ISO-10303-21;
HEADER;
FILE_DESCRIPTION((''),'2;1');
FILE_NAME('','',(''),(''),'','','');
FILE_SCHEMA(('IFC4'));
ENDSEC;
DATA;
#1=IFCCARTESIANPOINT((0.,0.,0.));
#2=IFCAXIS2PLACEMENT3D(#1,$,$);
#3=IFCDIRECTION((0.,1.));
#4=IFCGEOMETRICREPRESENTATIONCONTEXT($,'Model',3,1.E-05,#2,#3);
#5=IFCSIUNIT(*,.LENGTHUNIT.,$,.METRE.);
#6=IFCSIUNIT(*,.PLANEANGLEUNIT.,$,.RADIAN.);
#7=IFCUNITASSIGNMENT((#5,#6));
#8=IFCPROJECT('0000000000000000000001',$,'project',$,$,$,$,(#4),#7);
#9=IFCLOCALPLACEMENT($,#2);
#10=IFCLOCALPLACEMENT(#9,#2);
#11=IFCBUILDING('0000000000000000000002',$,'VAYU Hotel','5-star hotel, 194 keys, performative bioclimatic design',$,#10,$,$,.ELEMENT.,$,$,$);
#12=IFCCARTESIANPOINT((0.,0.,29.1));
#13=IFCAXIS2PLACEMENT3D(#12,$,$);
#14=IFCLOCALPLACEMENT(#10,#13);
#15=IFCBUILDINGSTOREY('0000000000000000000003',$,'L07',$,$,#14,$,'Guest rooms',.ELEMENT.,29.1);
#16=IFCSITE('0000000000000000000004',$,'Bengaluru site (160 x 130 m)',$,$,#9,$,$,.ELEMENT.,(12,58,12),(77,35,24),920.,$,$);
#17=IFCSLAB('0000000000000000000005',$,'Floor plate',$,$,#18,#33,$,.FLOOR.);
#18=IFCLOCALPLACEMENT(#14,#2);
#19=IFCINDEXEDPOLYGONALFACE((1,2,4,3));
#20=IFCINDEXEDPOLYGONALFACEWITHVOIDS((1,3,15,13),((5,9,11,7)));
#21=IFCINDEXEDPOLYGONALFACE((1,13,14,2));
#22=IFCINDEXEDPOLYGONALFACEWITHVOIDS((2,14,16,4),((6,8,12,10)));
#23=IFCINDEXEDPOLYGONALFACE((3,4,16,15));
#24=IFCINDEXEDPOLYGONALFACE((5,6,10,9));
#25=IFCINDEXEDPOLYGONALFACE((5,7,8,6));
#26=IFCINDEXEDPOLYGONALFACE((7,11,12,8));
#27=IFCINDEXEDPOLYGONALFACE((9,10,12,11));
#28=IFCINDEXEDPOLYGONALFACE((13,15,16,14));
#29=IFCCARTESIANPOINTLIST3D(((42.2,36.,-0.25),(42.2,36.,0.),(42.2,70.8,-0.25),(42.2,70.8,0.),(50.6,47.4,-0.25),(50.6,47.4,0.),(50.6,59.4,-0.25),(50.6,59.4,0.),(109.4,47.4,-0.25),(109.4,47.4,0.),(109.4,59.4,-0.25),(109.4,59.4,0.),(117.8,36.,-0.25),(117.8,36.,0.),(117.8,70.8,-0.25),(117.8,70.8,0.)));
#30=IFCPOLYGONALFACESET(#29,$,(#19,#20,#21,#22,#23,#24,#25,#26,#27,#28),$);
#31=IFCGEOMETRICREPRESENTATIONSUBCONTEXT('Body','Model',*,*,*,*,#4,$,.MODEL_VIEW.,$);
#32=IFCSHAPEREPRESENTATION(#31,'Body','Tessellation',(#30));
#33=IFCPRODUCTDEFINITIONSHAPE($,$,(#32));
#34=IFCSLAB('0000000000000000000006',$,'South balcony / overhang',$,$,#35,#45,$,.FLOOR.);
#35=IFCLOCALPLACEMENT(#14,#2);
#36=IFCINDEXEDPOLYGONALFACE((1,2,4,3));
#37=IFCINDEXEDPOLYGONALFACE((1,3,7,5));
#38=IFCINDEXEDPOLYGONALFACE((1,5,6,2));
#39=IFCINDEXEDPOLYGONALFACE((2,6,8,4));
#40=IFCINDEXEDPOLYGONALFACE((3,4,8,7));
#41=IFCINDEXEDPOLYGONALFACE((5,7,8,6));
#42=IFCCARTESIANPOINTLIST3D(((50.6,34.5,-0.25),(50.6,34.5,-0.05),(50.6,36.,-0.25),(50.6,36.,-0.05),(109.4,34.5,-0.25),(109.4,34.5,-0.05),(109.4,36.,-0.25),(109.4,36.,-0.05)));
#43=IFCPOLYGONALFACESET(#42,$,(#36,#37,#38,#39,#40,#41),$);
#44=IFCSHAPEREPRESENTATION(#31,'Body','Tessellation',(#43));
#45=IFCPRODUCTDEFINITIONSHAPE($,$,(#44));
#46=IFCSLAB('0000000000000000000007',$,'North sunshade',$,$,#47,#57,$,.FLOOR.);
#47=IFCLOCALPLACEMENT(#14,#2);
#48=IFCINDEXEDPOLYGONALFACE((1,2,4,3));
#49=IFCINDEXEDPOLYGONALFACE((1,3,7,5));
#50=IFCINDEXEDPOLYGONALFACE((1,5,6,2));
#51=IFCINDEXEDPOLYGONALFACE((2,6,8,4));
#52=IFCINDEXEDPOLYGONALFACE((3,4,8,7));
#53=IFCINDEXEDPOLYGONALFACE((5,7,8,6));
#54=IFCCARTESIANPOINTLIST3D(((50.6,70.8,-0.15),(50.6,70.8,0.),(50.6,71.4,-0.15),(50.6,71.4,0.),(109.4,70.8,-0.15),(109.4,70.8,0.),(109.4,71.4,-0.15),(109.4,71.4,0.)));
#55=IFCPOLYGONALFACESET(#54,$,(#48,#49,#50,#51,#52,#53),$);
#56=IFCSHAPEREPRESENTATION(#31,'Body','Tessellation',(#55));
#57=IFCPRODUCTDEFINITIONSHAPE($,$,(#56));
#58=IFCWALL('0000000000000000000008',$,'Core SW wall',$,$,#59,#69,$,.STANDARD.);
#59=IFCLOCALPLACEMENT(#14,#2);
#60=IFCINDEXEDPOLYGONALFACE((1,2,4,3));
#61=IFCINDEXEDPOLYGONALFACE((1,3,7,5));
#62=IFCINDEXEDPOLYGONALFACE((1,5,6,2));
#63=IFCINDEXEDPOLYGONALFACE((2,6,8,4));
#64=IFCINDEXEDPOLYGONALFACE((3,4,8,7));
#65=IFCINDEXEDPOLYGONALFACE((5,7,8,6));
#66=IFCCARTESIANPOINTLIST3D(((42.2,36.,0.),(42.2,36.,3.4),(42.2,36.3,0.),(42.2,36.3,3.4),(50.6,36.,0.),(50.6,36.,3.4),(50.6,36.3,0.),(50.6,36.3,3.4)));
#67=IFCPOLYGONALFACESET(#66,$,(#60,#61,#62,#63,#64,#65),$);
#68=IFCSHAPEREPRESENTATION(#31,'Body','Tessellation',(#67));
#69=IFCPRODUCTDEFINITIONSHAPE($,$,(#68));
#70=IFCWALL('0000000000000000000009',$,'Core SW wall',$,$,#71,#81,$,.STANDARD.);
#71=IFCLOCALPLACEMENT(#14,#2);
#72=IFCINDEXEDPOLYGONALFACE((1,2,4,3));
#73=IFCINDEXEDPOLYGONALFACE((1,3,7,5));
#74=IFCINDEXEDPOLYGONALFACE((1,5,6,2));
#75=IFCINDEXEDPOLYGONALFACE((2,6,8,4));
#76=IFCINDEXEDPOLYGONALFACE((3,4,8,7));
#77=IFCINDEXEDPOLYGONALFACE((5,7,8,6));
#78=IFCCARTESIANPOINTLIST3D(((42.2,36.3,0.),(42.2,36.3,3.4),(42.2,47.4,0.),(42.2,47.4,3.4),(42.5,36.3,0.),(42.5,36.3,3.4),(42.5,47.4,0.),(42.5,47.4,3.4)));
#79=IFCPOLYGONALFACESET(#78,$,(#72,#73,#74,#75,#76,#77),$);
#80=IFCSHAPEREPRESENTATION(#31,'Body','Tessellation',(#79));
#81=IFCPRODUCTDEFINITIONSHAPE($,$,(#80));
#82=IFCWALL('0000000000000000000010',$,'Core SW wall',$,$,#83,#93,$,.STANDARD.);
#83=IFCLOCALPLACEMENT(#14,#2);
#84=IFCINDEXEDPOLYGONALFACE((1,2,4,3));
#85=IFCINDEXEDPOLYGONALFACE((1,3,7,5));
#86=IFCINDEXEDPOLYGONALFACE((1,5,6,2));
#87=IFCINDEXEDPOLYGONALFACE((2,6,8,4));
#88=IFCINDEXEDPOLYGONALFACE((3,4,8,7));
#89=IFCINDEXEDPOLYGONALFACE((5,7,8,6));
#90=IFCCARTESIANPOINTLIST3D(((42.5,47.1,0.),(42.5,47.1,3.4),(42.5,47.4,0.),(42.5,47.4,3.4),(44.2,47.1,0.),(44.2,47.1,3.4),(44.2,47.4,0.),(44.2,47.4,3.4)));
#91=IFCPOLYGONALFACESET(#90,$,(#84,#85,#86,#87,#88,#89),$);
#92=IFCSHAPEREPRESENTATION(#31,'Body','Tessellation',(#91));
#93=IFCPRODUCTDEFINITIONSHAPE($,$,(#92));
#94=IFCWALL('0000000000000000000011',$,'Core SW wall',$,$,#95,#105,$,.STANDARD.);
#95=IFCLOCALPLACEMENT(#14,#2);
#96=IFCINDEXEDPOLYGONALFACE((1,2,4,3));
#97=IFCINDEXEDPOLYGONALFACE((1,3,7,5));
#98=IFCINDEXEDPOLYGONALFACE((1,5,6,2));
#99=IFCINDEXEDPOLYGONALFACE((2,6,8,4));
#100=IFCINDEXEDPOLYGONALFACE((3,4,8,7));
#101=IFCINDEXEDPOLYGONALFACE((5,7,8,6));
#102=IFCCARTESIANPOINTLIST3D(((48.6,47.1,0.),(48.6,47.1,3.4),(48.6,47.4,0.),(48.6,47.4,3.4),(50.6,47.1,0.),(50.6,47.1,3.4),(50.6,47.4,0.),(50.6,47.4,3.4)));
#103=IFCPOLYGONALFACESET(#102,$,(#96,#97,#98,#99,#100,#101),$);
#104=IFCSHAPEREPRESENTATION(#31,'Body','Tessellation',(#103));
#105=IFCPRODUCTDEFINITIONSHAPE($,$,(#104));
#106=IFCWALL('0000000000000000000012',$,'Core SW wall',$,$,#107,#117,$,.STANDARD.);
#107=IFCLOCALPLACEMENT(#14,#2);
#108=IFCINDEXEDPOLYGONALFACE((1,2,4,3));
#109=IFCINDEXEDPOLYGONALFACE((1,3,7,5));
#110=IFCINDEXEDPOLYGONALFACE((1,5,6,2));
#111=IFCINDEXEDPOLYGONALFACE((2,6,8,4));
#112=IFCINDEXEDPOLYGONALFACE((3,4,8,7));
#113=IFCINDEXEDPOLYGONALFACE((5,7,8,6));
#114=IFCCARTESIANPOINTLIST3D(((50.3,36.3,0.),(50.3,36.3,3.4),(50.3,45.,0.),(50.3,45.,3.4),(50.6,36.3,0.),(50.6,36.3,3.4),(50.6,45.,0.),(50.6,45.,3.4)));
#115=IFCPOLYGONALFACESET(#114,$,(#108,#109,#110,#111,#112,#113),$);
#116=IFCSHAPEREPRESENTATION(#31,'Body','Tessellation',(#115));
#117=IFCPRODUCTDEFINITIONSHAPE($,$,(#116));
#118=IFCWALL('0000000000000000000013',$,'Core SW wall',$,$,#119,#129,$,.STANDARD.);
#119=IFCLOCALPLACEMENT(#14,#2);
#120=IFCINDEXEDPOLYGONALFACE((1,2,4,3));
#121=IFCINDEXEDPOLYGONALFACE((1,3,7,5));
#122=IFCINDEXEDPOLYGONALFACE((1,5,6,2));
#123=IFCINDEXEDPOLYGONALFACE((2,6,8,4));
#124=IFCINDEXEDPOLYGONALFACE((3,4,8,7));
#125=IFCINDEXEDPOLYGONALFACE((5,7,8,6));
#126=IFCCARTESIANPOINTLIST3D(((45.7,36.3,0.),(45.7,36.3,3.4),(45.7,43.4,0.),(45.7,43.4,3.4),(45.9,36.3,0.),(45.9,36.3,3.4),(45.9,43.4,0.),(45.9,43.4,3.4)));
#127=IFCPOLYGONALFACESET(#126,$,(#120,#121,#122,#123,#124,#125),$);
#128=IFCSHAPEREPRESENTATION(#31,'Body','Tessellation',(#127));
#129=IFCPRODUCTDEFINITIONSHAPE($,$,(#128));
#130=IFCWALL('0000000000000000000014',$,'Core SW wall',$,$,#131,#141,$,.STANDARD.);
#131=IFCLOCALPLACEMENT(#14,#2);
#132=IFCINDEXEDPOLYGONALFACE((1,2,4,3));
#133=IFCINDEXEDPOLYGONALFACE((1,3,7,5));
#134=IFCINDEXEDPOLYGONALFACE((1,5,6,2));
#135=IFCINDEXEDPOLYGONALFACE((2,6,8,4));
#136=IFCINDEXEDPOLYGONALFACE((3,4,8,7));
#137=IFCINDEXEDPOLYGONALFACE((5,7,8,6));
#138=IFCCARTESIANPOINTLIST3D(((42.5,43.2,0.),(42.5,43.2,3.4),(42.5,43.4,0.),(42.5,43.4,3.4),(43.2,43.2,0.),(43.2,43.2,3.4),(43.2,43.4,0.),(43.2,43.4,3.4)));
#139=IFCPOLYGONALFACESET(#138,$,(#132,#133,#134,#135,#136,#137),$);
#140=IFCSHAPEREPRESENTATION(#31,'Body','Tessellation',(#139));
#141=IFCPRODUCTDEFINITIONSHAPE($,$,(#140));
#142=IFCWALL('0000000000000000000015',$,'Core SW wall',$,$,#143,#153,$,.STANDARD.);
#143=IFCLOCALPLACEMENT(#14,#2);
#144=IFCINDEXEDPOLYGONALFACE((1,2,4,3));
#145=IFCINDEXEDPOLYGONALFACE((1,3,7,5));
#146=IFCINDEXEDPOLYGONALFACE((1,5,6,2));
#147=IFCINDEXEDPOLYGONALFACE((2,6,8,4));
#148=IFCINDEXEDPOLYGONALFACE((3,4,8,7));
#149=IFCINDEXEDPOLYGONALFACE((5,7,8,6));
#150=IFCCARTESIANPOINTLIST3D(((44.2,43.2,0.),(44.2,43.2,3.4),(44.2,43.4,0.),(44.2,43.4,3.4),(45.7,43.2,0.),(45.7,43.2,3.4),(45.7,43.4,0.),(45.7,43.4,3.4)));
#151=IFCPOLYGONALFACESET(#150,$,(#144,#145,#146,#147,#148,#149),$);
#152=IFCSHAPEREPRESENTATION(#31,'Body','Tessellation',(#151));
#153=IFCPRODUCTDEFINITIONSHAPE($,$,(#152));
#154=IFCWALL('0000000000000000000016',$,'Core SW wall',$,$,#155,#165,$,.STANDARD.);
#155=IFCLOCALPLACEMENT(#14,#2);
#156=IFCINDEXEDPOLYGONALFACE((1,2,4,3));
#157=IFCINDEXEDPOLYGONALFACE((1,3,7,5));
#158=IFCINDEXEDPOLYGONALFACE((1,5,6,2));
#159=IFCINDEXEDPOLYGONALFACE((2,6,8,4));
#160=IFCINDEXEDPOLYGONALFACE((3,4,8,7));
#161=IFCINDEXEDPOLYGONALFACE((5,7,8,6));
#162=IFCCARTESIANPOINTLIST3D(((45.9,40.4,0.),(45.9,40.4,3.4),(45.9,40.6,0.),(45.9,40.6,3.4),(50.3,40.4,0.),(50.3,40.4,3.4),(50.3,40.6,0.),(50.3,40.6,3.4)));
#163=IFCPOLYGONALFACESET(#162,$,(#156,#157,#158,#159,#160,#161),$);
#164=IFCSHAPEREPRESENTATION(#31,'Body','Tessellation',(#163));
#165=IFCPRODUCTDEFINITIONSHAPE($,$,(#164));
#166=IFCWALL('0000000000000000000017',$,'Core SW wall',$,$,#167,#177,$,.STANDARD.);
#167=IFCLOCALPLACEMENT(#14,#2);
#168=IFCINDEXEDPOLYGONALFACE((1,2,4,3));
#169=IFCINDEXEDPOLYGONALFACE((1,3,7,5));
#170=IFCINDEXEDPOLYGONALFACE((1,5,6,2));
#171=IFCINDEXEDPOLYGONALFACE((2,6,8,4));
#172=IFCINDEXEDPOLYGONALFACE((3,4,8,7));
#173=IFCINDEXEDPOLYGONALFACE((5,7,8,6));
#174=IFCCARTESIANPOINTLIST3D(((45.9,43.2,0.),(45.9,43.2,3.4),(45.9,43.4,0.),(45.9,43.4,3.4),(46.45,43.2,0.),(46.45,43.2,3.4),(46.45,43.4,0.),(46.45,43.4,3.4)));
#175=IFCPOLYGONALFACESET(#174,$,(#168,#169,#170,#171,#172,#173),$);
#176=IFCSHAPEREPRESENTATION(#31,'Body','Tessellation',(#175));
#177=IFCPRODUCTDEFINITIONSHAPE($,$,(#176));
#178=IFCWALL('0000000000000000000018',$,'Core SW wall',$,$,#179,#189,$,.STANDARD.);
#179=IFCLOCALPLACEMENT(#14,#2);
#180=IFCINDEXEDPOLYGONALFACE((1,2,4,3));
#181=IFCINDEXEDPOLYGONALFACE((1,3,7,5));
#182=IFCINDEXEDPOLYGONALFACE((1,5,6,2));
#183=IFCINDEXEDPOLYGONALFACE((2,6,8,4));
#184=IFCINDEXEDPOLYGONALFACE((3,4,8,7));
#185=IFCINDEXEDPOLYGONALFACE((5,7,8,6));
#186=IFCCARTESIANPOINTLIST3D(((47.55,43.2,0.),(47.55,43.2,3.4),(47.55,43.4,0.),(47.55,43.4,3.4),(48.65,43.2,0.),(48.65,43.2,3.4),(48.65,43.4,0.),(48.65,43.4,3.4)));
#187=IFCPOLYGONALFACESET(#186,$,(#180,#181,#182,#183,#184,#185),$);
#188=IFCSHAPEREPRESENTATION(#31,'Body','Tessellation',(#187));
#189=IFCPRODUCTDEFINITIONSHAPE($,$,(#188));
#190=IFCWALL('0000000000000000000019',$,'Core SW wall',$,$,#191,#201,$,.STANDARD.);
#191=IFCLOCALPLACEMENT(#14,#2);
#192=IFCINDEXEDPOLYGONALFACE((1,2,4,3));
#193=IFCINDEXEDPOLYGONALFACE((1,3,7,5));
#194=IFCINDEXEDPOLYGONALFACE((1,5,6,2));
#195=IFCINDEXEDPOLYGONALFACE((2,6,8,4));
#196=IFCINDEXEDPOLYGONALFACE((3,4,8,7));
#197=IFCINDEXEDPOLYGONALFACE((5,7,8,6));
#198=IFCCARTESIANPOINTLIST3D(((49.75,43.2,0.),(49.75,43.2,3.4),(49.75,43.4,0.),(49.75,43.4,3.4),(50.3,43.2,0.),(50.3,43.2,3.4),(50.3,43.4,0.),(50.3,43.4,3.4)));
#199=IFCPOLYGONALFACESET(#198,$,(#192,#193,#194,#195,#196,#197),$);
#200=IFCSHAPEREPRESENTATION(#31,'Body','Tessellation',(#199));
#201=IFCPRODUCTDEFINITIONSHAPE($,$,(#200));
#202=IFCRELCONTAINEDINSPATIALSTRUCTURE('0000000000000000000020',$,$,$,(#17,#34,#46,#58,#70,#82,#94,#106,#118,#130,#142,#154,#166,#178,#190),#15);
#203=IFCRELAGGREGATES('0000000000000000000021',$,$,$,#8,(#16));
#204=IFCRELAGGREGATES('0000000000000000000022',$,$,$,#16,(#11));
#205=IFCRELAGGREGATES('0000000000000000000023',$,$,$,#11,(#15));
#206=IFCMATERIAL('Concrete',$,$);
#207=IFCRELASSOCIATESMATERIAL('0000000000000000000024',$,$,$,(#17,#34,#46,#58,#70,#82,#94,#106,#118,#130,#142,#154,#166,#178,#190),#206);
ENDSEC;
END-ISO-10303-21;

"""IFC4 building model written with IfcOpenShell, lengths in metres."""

from ifc_helpers import new_model, si_unit, direction, frame, origin, place, context, subcontext, project, spatial, polyline, outline, extrude, material, element, save


model = new_model("IFC4")

# Units and contexts
model_context = context("Model", 3, precision=1e-05, world=origin(), true_north=direction((0.0, 1.0)))
body_context = subcontext(model_context, "Body", "Model", "MODEL_VIEW")
ifc_project = project(units=[si_unit("LENGTHUNIT", "METRE"), si_unit("PLANEANGLEUNIT", "RADIAN")], contexts=[model_context])

# Site, building, storey
site_placement = place(None, origin())
site = spatial("IfcSite", under=ifc_project, at=site_placement, Name="Bengaluru site (160 x 130 m)", CompositionType="ELEMENT", RefLatitude=(12, 58, 12), RefLongitude=(77, 35, 24), RefElevation=920.0)
building_placement = place(site_placement, origin())
building = spatial("IfcBuilding", under=site, at=building_placement, Name="VAYU Hotel", Description="5-star hotel, 194 keys, performative bioclimatic design", CompositionType="ELEMENT")
storey_placement = place(building_placement, frame((0.0, 0.0, 29.1)))
storey = spatial("IfcBuildingStorey", under=building, at=storey_placement, Name="L07", LongName="Guest rooms", CompositionType="ELEMENT", Elevation=29.1)

# Slabs
ifc_material_1 = material(Name="Concrete")
slab_1_placement = place(storey_placement, origin())
element("IfcSlab", 1, at=slab_1_placement, inside=storey, material=ifc_material_1, Name="Floor plate", PredefinedType="FLOOR", context=body_context, shape_type="SweptSolid", body=[
    extrude(outline(polyline([(42.2, 36.0), (117.8, 36.0), (117.8, 70.8), (42.2, 70.8), (42.2, 36.0)]), holes=[polyline([(50.6, 47.4), (109.4, 47.4), (109.4, 59.4), (50.6, 59.4), (50.6, 47.4)])]), frame((0.0, 0.0, -0.25)), (0.0, 0.0, 1.0), 0.25),
])
slab_2_placement = place(storey_placement, origin())
element("IfcSlab", 2, at=slab_2_placement, inside=storey, material=ifc_material_1, Name="South balcony / overhang", PredefinedType="FLOOR", context=body_context, shape_type="SweptSolid", body=[
    extrude(outline(polyline([(50.6, 34.5), (109.4, 34.5), (109.4, 36.0), (50.6, 36.0), (50.6, 34.5)])), frame((0.0, 0.0, -0.25)), (0.0, 0.0, 1.0), 0.2),
])
slab_3_placement = place(storey_placement, origin())
element("IfcSlab", 3, at=slab_3_placement, inside=storey, material=ifc_material_1, Name="North sunshade", PredefinedType="FLOOR", context=body_context, shape_type="SweptSolid", body=[
    extrude(outline(polyline([(50.6, 70.8), (109.4, 70.8), (109.4, 71.4), (50.6, 71.4), (50.6, 70.8)])), frame((0.0, 0.0, -0.15)), (0.0, 0.0, 1.0), 0.15),
])

# Walls
wall_1_placement = place(storey_placement, origin())
element("IfcWall", 4, at=wall_1_placement, inside=storey, material=ifc_material_1, Name="Core SW wall", PredefinedType="STANDARD", context=body_context, shape_type="SweptSolid", body=[
    extrude(outline(polyline([(42.2, 36.3), (50.6, 36.3), (50.6, 36.0), (42.2, 36.0), (42.2, 36.3)])), origin(), (0.0, 0.0, 1.0), 3.4),
])
wall_2_placement = place(storey_placement, origin())
element("IfcWall", 5, at=wall_2_placement, inside=storey, material=ifc_material_1, Name="Core SW wall", PredefinedType="STANDARD", context=body_context, shape_type="SweptSolid", body=[
    extrude(outline(polyline([(42.2, 36.3), (42.2, 47.4), (42.5, 47.4), (42.5, 36.3), (42.2, 36.3)])), origin(), (0.0, 0.0, 1.0), 3.4),
])
wall_3_placement = place(storey_placement, origin())
element("IfcWall", 6, at=wall_3_placement, inside=storey, material=ifc_material_1, Name="Core SW wall", PredefinedType="STANDARD", context=body_context, shape_type="SweptSolid", body=[
    extrude(outline(polyline([(42.5, 47.4), (44.2, 47.4), (44.2, 47.1), (42.5, 47.1), (42.5, 47.4)])), origin(), (0.0, 0.0, 1.0), 3.4),
])
wall_4_placement = place(storey_placement, origin())
element("IfcWall", 7, at=wall_4_placement, inside=storey, material=ifc_material_1, Name="Core SW wall", PredefinedType="STANDARD", context=body_context, shape_type="SweptSolid", body=[
    extrude(outline(polyline([(48.6, 47.4), (50.6, 47.4), (50.6, 47.1), (48.6, 47.1), (48.6, 47.4)])), origin(), (0.0, 0.0, 1.0), 3.4),
])
wall_5_placement = place(storey_placement, origin())
element("IfcWall", 8, at=wall_5_placement, inside=storey, material=ifc_material_1, Name="Core SW wall", PredefinedType="STANDARD", context=body_context, shape_type="SweptSolid", body=[
    extrude(outline(polyline([(50.3, 36.3), (50.3, 45.0), (50.6, 45.0), (50.6, 36.3), (50.3, 36.3)])), origin(), (0.0, 0.0, 1.0), 3.4),
])
wall_6_placement = place(storey_placement, origin())
element("IfcWall", 9, at=wall_6_placement, inside=storey, material=ifc_material_1, Name="Core SW wall", PredefinedType="STANDARD", context=body_context, shape_type="SweptSolid", body=[
    extrude(outline(polyline([(45.7, 36.3), (45.7, 43.4), (45.9, 43.4), (45.9, 36.3), (45.7, 36.3)])), origin(), (0.0, 0.0, 1.0), 3.4),
])
wall_7_placement = place(storey_placement, origin())
element("IfcWall", 10, at=wall_7_placement, inside=storey, material=ifc_material_1, Name="Core SW wall", PredefinedType="STANDARD", context=body_context, shape_type="SweptSolid", body=[
    extrude(outline(polyline([(42.5, 43.4), (43.2, 43.4), (43.2, 43.2), (42.5, 43.2), (42.5, 43.4)])), origin(), (0.0, 0.0, 1.0), 3.4),
])
wall_8_placement = place(storey_placement, origin())
element("IfcWall", 11, at=wall_8_placement, inside=storey, material=ifc_material_1, Name="Core SW wall", PredefinedType="STANDARD", context=body_context, shape_type="SweptSolid", body=[
    extrude(outline(polyline([(44.2, 43.4), (45.7, 43.4), (45.7, 43.2), (44.2, 43.2), (44.2, 43.4)])), origin(), (0.0, 0.0, 1.0), 3.4),
])
wall_9_placement = place(storey_placement, origin())
element("IfcWall", 12, at=wall_9_placement, inside=storey, material=ifc_material_1, Name="Core SW wall", PredefinedType="STANDARD", context=body_context, shape_type="SweptSolid", body=[
    extrude(outline(polyline([(45.9, 40.6), (50.3, 40.6), (50.3, 40.4), (45.9, 40.4), (45.9, 40.6)])), origin(), (0.0, 0.0, 1.0), 3.4),
])
wall_10_placement = place(storey_placement, origin())
element("IfcWall", 13, at=wall_10_placement, inside=storey, material=ifc_material_1, Name="Core SW wall", PredefinedType="STANDARD", context=body_context, shape_type="SweptSolid", body=[
    extrude(outline(polyline([(45.9, 43.4), (46.45, 43.4), (46.45, 43.2), (45.9, 43.2), (45.9, 43.4)])), origin(), (0.0, 0.0, 1.0), 3.4),
])
wall_11_placement = place(storey_placement, origin())
element("IfcWall", 14, at=wall_11_placement, inside=storey, material=ifc_material_1, Name="Core SW wall", PredefinedType="STANDARD", context=body_context, shape_type="SweptSolid", body=[
    extrude(outline(polyline([(47.55, 43.4), (48.65, 43.4), (48.65, 43.2), (47.55, 43.2), (47.55, 43.4)])), origin(), (0.0, 0.0, 1.0), 3.4),
])
wall_12_placement = place(storey_placement, origin())
element("IfcWall", 15, at=wall_12_placement, inside=storey, material=ifc_material_1, Name="Core SW wall", PredefinedType="STANDARD", context=body_context, shape_type="SweptSolid", body=[
    extrude(outline(polyline([(49.75, 43.4), (50.3, 43.4), (50.3, 43.2), (49.75, 43.2), (49.75, 43.4)])), origin(), (0.0, 0.0, 1.0), 3.4),
])

save(model, "model.ifc")
